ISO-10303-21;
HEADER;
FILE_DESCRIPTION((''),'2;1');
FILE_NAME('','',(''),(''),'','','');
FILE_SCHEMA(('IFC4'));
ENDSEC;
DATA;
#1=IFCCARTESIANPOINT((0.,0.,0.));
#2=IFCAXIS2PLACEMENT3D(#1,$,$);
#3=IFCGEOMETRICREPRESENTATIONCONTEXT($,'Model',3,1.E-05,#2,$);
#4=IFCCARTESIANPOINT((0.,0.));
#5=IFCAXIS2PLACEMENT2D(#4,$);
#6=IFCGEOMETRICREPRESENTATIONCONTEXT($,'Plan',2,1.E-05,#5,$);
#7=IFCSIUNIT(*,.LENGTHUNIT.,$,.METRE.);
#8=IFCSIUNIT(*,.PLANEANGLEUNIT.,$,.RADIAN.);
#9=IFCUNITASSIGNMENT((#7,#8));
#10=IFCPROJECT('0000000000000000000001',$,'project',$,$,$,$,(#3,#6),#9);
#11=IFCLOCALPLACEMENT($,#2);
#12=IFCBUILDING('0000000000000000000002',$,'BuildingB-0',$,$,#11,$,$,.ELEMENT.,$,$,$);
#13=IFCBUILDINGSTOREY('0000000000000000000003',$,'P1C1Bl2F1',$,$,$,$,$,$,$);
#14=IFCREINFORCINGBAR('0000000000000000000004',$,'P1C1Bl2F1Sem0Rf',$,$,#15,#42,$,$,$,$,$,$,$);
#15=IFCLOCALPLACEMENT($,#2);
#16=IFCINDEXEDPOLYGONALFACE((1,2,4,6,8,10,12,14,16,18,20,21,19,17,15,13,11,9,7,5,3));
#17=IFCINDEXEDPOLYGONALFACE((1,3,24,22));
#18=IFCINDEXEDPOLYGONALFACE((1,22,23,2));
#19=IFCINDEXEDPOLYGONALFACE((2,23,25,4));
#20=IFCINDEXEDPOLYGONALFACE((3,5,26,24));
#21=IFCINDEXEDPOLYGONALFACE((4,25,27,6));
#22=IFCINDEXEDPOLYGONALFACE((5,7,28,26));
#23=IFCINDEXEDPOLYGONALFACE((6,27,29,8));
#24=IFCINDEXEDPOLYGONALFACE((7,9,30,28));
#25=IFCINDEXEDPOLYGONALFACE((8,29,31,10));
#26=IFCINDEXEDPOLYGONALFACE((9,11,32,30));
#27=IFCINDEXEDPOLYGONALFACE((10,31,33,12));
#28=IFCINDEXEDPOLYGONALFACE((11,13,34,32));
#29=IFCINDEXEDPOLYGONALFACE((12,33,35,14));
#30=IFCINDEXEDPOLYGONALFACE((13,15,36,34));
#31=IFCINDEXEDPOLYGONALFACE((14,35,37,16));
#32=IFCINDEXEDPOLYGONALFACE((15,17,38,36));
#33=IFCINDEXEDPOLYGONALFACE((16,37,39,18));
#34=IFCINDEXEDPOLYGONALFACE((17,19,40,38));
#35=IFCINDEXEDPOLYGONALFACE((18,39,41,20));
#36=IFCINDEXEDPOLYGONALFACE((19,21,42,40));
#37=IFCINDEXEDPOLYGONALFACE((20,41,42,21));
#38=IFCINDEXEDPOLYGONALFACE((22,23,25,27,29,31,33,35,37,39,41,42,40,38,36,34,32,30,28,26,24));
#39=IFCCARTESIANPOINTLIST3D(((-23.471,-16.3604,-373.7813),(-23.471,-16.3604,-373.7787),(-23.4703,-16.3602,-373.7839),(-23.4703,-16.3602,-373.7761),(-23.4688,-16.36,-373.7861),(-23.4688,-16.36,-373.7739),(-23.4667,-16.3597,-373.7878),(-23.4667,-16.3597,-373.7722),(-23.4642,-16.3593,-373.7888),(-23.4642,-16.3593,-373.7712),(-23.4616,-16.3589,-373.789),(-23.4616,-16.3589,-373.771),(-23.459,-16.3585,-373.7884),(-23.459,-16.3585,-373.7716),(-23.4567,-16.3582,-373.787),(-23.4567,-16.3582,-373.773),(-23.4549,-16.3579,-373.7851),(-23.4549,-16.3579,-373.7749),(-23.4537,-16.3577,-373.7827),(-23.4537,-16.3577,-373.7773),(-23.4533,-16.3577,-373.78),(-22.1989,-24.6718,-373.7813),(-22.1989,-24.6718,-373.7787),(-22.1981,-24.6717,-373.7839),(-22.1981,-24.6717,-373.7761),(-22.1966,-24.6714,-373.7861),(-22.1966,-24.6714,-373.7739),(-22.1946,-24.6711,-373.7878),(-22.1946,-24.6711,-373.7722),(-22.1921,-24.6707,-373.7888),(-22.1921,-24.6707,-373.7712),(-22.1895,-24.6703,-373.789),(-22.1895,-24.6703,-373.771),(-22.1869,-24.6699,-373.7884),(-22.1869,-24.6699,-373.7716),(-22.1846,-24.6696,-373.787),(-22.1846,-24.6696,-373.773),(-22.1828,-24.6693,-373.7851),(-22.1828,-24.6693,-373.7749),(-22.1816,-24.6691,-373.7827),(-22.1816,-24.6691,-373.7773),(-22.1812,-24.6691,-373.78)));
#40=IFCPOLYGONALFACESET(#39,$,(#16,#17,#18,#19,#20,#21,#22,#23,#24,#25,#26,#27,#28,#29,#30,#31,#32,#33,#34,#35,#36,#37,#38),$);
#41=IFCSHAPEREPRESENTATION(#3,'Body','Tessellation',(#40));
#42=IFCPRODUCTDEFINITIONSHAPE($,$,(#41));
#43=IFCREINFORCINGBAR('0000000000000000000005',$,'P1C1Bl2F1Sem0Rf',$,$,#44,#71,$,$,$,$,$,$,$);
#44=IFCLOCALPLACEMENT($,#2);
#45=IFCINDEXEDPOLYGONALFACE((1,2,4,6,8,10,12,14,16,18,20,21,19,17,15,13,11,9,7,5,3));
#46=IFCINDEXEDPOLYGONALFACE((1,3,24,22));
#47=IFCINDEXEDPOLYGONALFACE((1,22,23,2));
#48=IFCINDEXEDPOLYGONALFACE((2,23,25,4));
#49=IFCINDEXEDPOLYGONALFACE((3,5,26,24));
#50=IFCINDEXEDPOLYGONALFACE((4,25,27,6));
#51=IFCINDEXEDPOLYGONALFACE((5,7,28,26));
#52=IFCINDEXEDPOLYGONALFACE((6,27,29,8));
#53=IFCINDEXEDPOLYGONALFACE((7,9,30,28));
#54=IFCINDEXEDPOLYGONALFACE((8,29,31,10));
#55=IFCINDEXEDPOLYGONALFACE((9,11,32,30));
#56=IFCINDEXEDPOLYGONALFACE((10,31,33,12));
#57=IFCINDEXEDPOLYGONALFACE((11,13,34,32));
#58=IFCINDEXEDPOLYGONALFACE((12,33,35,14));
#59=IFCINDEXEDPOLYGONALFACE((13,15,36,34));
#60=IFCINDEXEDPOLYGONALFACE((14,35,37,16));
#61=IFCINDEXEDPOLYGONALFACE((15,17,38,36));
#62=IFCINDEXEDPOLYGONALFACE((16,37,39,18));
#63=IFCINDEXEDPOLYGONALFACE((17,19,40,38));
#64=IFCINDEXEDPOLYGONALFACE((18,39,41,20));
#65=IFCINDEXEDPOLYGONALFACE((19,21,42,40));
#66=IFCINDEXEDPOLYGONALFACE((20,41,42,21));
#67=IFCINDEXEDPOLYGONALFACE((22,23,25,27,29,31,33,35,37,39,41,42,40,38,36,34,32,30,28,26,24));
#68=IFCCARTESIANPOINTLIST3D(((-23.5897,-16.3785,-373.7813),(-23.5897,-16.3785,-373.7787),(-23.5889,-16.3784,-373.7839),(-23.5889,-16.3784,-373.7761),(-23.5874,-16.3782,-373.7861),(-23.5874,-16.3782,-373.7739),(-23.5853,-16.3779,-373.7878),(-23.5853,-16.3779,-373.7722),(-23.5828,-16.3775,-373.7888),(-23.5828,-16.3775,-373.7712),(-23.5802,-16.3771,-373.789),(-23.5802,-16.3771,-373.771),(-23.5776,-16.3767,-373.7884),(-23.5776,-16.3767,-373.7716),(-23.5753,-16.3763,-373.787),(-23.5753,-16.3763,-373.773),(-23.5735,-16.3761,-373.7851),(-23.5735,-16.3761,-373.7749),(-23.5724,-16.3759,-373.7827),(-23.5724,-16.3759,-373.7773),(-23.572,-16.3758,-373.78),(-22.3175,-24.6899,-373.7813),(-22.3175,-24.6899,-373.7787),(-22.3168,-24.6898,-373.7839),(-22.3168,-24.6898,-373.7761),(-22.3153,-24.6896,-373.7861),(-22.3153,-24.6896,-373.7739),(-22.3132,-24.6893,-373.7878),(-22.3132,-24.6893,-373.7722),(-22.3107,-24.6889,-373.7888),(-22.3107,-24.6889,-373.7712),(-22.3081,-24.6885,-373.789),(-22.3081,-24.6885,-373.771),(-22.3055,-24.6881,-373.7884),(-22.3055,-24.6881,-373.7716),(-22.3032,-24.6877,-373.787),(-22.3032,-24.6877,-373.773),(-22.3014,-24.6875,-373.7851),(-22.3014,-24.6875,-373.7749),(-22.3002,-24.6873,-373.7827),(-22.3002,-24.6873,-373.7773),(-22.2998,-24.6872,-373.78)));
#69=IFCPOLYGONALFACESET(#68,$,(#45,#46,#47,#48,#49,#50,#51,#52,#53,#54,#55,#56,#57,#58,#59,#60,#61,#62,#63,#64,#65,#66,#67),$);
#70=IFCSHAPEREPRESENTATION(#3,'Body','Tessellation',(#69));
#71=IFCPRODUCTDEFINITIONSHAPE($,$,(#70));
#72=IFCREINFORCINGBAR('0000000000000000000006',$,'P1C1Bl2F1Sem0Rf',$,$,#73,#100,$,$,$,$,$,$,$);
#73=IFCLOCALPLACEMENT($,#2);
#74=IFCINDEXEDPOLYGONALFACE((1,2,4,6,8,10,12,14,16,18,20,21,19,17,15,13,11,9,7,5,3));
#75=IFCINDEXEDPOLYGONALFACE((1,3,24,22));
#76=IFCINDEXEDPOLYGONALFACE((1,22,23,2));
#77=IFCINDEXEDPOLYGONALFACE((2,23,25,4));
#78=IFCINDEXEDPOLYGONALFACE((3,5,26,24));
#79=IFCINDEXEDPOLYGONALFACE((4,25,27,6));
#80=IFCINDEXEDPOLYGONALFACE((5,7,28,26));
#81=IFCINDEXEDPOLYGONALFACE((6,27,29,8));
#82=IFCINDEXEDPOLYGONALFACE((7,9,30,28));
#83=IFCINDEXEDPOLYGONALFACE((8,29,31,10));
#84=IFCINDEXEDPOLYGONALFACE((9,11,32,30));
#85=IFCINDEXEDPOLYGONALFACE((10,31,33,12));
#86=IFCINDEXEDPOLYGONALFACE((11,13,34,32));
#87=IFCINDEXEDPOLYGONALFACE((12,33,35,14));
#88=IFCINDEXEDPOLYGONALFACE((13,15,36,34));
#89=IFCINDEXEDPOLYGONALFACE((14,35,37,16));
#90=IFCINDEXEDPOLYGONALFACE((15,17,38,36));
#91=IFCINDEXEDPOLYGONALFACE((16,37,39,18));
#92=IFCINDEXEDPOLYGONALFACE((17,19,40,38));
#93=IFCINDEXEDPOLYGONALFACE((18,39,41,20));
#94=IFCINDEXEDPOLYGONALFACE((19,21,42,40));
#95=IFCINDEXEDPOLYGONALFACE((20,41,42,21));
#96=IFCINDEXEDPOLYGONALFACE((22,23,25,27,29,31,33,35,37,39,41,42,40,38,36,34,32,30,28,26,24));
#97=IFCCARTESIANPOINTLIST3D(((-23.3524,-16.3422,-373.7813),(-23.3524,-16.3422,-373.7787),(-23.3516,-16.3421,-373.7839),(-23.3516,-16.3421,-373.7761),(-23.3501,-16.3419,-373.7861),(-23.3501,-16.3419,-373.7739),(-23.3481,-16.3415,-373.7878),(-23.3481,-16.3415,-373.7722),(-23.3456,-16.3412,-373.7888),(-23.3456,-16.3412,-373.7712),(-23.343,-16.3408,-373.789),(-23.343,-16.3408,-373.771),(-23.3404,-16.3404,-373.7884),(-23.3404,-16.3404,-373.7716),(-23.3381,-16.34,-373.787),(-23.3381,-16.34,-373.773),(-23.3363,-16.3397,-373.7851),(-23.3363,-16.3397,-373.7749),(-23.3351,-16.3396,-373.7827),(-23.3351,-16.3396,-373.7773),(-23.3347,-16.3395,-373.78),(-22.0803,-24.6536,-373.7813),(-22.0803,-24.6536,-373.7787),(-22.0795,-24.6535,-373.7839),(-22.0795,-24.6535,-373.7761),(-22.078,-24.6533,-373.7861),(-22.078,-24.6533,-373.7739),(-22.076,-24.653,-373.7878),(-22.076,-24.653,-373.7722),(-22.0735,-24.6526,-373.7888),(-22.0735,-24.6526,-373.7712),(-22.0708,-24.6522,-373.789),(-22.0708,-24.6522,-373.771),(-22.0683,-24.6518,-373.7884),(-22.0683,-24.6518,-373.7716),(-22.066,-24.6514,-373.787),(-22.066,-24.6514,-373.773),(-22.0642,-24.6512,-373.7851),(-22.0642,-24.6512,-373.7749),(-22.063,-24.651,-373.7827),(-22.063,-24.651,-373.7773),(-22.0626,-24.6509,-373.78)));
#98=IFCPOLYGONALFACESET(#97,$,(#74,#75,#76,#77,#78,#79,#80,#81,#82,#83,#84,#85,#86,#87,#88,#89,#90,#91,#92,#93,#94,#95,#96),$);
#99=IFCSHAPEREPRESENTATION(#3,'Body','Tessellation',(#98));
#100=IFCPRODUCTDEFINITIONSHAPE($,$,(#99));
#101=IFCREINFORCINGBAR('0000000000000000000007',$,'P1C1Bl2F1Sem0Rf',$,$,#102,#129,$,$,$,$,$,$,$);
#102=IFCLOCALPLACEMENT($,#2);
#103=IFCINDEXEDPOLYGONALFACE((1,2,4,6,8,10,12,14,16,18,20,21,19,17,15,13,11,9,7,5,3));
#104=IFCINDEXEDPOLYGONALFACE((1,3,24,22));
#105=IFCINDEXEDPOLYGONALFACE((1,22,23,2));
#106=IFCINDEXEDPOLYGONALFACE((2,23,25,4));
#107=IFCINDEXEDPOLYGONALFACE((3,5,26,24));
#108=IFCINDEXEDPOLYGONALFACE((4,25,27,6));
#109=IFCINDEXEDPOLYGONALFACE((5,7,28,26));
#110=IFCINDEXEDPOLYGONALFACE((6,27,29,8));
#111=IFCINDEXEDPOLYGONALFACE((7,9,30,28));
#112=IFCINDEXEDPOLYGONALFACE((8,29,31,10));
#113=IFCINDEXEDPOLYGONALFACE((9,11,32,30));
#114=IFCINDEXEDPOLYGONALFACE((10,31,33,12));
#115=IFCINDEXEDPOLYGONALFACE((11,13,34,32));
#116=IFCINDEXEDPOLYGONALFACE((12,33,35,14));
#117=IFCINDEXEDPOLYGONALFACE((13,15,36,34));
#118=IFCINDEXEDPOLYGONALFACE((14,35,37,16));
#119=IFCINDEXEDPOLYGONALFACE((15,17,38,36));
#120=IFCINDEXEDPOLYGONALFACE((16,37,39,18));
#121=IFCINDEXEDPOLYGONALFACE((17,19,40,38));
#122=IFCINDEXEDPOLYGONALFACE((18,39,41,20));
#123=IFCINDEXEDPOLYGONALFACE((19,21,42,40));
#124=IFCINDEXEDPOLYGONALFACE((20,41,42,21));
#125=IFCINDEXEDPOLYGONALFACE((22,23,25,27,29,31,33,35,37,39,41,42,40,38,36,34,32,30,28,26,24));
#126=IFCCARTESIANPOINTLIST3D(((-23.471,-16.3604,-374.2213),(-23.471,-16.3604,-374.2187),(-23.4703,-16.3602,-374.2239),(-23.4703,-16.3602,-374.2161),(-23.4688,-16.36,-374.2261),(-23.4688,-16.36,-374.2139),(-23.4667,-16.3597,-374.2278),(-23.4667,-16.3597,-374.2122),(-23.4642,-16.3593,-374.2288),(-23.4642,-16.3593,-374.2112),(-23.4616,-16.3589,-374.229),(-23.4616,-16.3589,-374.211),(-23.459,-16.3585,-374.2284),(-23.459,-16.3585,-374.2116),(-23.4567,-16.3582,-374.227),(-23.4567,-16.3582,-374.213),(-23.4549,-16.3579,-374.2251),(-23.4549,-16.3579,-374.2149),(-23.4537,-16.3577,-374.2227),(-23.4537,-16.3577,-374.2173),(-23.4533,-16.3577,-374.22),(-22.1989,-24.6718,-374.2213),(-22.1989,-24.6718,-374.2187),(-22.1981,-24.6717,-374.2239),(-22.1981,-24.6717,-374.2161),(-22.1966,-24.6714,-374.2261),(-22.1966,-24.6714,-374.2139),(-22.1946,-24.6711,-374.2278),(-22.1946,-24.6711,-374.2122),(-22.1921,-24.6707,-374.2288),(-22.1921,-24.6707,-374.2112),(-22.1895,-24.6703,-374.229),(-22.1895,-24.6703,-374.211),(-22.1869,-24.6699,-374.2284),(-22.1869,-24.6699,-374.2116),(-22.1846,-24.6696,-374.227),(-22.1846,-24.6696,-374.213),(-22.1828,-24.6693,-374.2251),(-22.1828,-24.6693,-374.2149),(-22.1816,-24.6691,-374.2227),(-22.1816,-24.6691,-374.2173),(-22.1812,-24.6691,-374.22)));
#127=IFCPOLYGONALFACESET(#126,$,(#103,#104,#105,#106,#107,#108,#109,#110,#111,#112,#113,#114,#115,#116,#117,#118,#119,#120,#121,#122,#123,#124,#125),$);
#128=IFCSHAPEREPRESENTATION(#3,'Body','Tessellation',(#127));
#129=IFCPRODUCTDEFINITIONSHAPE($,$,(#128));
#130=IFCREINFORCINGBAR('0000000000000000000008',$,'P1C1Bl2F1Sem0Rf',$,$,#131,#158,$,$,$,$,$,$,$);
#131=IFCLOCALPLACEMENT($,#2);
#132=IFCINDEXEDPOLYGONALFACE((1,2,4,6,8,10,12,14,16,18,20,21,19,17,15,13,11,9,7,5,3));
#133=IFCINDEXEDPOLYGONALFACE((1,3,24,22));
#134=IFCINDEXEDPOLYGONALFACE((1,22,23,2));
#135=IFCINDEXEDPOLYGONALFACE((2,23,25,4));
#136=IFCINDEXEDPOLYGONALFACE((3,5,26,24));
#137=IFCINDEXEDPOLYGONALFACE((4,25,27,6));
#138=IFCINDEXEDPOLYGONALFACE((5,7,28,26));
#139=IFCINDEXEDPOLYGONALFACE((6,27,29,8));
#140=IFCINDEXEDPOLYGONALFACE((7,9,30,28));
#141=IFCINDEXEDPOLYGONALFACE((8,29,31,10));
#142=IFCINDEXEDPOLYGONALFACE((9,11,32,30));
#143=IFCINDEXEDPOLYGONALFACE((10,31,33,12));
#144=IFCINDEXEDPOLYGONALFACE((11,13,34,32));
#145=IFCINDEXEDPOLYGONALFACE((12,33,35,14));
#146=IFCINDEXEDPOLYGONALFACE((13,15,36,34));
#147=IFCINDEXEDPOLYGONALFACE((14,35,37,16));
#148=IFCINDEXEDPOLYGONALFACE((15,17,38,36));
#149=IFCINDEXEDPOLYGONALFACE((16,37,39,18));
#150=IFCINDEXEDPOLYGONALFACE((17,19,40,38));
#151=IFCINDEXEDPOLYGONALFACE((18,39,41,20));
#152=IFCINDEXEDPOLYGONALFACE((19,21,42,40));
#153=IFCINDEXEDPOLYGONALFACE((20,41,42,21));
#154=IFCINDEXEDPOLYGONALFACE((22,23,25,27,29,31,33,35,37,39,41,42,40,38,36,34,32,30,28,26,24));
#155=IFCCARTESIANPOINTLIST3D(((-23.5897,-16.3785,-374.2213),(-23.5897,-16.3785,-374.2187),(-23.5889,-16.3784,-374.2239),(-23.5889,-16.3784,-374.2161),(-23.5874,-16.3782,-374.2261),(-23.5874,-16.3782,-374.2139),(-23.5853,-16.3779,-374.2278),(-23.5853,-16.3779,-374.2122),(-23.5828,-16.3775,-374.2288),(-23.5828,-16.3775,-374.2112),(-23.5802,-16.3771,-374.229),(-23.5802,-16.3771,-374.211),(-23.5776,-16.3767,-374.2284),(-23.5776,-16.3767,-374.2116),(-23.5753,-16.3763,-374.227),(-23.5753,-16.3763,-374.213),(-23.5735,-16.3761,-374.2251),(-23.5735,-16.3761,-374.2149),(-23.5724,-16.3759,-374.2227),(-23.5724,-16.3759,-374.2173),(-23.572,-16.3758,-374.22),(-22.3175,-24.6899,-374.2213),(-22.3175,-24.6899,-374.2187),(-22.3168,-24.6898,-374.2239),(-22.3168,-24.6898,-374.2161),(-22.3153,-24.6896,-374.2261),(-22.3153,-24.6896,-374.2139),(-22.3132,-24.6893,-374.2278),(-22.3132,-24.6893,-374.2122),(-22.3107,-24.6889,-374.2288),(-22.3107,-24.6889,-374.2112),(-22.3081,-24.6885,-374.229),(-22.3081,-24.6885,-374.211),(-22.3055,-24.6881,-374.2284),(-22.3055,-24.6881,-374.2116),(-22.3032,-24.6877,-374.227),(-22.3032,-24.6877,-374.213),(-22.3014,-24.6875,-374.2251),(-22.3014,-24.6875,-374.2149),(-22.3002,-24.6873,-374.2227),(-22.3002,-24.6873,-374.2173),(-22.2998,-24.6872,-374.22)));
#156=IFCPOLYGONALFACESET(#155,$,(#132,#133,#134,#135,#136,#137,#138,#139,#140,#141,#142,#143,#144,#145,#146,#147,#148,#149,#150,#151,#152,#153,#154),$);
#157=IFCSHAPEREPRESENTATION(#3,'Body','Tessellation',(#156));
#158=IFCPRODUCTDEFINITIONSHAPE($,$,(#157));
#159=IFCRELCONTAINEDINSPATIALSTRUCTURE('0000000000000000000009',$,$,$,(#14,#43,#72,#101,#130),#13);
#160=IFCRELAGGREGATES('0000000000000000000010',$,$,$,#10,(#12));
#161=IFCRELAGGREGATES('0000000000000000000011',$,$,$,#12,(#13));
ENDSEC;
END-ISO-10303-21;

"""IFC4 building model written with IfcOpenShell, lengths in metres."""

from ifc_helpers import new_model, entity, si_unit, origin, origin_2d, place, context, project, spatial, element, save


model = new_model("IFC4")

# Units and contexts
model_context = context("Model", 3, precision=1e-05, world=origin())
plan_context = context("Plan", 2, precision=1e-05, world=origin_2d())
ifc_project = project(units=[si_unit("LENGTHUNIT", "METRE"), si_unit("PLANEANGLEUNIT", "RADIAN")], contexts=[model_context, plan_context])

# Building, storey
building_placement = place(None, origin())
building = spatial("IfcBuilding", under=ifc_project, at=building_placement, Name="BuildingB-0", CompositionType="ELEMENT")
storey = spatial("IfcBuildingStorey", under=building, Name="P1C1Bl2F1")

# Reinforcing bars
element("IfcReinforcingBar", 1, inside=storey, Name="P1C1Bl2F1Sem0Rf", context=model_context, shape_type="SweptSolid", body=[
    entity("IfcSurfaceCurveSweptAreaSolid", entity("IfcCircleProfileDef", "AREA", None, None, 0.009), None, entity("IfcPolyline", [entity("IfcCartesianPoint", [23.4622, 16.359, 373.78]), entity("IfcCartesianPoint", [22.1901, 24.6704, 373.78])]), None, None, entity("IfcPlane", entity("IfcAxis2Placement3D", entity("IfcCartesianPoint", [23.4622, 16.359, 373.78]), entity("IfcDirection", [0.0, 0.0, 1.0]), entity("IfcDirection", [1.0, 0.0, 0.0])))),
])
element("IfcReinforcingBar", 2, inside=storey, Name="P1C1Bl2F1Sem0Rf", context=model_context, shape_type="SweptSolid", body=[
    entity("IfcSurfaceCurveSweptAreaSolid", entity("IfcCircleProfileDef", "AREA", None, None, 0.009), None, entity("IfcPolyline", [entity("IfcCartesianPoint", [23.5809, 16.3772, 373.78]), entity("IfcCartesianPoint", [22.3087, 24.6886, 373.78])]), None, None, entity("IfcPlane", entity("IfcAxis2Placement3D", entity("IfcCartesianPoint", [23.5809, 16.3772, 373.78]), entity("IfcDirection", [0.0, 0.0, 1.0]), entity("IfcDirection", [1.0, 0.0, 0.0])))),
])
element("IfcReinforcingBar", 3, inside=storey, Name="P1C1Bl2F1Sem0Rf", context=model_context, shape_type="SweptSolid", body=[
    entity("IfcSurfaceCurveSweptAreaSolid", entity("IfcCircleProfileDef", "AREA", None, None, 0.009), None, entity("IfcPolyline", [entity("IfcCartesianPoint", [23.3436, 16.3409, 373.78]), entity("IfcCartesianPoint", [22.0715, 24.6523, 373.78])]), None, None, entity("IfcPlane", entity("IfcAxis2Placement3D", entity("IfcCartesianPoint", [23.3436, 16.3409, 373.78]), entity("IfcDirection", [0.0, 0.0, 1.0]), entity("IfcDirection", [1.0, 0.0, 0.0])))),
])
element("IfcReinforcingBar", 4, inside=storey, Name="P1C1Bl2F1Sem0Rf", context=model_context, shape_type="SweptSolid", body=[
    entity("IfcSurfaceCurveSweptAreaSolid", entity("IfcCircleProfileDef", "AREA", None, None, 0.009), None, entity("IfcPolyline", [entity("IfcCartesianPoint", [23.4622, 16.359, 374.22]), entity("IfcCartesianPoint", [22.1901, 24.6704, 374.22])]), None, None, entity("IfcPlane", entity("IfcAxis2Placement3D", entity("IfcCartesianPoint", [23.4622, 16.359, 374.22]), entity("IfcDirection", [0.0, 0.0, 1.0]), entity("IfcDirection", [1.0, 0.0, 0.0])))),
])
element("IfcReinforcingBar", 5, inside=storey, Name="P1C1Bl2F1Sem0Rf", context=model_context, shape_type="SweptSolid", body=[
    entity("IfcSurfaceCurveSweptAreaSolid", entity("IfcCircleProfileDef", "AREA", None, None, 0.009), None, entity("IfcPolyline", [entity("IfcCartesianPoint", [23.5809, 16.3772, 374.22]), entity("IfcCartesianPoint", [22.3087, 24.6886, 374.22])]), None, None, entity("IfcPlane", entity("IfcAxis2Placement3D", entity("IfcCartesianPoint", [23.5809, 16.3772, 374.22]), entity("IfcDirection", [0.0, 0.0, 1.0]), entity("IfcDirection", [1.0, 0.0, 0.0])))),
])

save(model, "model.ifc")
